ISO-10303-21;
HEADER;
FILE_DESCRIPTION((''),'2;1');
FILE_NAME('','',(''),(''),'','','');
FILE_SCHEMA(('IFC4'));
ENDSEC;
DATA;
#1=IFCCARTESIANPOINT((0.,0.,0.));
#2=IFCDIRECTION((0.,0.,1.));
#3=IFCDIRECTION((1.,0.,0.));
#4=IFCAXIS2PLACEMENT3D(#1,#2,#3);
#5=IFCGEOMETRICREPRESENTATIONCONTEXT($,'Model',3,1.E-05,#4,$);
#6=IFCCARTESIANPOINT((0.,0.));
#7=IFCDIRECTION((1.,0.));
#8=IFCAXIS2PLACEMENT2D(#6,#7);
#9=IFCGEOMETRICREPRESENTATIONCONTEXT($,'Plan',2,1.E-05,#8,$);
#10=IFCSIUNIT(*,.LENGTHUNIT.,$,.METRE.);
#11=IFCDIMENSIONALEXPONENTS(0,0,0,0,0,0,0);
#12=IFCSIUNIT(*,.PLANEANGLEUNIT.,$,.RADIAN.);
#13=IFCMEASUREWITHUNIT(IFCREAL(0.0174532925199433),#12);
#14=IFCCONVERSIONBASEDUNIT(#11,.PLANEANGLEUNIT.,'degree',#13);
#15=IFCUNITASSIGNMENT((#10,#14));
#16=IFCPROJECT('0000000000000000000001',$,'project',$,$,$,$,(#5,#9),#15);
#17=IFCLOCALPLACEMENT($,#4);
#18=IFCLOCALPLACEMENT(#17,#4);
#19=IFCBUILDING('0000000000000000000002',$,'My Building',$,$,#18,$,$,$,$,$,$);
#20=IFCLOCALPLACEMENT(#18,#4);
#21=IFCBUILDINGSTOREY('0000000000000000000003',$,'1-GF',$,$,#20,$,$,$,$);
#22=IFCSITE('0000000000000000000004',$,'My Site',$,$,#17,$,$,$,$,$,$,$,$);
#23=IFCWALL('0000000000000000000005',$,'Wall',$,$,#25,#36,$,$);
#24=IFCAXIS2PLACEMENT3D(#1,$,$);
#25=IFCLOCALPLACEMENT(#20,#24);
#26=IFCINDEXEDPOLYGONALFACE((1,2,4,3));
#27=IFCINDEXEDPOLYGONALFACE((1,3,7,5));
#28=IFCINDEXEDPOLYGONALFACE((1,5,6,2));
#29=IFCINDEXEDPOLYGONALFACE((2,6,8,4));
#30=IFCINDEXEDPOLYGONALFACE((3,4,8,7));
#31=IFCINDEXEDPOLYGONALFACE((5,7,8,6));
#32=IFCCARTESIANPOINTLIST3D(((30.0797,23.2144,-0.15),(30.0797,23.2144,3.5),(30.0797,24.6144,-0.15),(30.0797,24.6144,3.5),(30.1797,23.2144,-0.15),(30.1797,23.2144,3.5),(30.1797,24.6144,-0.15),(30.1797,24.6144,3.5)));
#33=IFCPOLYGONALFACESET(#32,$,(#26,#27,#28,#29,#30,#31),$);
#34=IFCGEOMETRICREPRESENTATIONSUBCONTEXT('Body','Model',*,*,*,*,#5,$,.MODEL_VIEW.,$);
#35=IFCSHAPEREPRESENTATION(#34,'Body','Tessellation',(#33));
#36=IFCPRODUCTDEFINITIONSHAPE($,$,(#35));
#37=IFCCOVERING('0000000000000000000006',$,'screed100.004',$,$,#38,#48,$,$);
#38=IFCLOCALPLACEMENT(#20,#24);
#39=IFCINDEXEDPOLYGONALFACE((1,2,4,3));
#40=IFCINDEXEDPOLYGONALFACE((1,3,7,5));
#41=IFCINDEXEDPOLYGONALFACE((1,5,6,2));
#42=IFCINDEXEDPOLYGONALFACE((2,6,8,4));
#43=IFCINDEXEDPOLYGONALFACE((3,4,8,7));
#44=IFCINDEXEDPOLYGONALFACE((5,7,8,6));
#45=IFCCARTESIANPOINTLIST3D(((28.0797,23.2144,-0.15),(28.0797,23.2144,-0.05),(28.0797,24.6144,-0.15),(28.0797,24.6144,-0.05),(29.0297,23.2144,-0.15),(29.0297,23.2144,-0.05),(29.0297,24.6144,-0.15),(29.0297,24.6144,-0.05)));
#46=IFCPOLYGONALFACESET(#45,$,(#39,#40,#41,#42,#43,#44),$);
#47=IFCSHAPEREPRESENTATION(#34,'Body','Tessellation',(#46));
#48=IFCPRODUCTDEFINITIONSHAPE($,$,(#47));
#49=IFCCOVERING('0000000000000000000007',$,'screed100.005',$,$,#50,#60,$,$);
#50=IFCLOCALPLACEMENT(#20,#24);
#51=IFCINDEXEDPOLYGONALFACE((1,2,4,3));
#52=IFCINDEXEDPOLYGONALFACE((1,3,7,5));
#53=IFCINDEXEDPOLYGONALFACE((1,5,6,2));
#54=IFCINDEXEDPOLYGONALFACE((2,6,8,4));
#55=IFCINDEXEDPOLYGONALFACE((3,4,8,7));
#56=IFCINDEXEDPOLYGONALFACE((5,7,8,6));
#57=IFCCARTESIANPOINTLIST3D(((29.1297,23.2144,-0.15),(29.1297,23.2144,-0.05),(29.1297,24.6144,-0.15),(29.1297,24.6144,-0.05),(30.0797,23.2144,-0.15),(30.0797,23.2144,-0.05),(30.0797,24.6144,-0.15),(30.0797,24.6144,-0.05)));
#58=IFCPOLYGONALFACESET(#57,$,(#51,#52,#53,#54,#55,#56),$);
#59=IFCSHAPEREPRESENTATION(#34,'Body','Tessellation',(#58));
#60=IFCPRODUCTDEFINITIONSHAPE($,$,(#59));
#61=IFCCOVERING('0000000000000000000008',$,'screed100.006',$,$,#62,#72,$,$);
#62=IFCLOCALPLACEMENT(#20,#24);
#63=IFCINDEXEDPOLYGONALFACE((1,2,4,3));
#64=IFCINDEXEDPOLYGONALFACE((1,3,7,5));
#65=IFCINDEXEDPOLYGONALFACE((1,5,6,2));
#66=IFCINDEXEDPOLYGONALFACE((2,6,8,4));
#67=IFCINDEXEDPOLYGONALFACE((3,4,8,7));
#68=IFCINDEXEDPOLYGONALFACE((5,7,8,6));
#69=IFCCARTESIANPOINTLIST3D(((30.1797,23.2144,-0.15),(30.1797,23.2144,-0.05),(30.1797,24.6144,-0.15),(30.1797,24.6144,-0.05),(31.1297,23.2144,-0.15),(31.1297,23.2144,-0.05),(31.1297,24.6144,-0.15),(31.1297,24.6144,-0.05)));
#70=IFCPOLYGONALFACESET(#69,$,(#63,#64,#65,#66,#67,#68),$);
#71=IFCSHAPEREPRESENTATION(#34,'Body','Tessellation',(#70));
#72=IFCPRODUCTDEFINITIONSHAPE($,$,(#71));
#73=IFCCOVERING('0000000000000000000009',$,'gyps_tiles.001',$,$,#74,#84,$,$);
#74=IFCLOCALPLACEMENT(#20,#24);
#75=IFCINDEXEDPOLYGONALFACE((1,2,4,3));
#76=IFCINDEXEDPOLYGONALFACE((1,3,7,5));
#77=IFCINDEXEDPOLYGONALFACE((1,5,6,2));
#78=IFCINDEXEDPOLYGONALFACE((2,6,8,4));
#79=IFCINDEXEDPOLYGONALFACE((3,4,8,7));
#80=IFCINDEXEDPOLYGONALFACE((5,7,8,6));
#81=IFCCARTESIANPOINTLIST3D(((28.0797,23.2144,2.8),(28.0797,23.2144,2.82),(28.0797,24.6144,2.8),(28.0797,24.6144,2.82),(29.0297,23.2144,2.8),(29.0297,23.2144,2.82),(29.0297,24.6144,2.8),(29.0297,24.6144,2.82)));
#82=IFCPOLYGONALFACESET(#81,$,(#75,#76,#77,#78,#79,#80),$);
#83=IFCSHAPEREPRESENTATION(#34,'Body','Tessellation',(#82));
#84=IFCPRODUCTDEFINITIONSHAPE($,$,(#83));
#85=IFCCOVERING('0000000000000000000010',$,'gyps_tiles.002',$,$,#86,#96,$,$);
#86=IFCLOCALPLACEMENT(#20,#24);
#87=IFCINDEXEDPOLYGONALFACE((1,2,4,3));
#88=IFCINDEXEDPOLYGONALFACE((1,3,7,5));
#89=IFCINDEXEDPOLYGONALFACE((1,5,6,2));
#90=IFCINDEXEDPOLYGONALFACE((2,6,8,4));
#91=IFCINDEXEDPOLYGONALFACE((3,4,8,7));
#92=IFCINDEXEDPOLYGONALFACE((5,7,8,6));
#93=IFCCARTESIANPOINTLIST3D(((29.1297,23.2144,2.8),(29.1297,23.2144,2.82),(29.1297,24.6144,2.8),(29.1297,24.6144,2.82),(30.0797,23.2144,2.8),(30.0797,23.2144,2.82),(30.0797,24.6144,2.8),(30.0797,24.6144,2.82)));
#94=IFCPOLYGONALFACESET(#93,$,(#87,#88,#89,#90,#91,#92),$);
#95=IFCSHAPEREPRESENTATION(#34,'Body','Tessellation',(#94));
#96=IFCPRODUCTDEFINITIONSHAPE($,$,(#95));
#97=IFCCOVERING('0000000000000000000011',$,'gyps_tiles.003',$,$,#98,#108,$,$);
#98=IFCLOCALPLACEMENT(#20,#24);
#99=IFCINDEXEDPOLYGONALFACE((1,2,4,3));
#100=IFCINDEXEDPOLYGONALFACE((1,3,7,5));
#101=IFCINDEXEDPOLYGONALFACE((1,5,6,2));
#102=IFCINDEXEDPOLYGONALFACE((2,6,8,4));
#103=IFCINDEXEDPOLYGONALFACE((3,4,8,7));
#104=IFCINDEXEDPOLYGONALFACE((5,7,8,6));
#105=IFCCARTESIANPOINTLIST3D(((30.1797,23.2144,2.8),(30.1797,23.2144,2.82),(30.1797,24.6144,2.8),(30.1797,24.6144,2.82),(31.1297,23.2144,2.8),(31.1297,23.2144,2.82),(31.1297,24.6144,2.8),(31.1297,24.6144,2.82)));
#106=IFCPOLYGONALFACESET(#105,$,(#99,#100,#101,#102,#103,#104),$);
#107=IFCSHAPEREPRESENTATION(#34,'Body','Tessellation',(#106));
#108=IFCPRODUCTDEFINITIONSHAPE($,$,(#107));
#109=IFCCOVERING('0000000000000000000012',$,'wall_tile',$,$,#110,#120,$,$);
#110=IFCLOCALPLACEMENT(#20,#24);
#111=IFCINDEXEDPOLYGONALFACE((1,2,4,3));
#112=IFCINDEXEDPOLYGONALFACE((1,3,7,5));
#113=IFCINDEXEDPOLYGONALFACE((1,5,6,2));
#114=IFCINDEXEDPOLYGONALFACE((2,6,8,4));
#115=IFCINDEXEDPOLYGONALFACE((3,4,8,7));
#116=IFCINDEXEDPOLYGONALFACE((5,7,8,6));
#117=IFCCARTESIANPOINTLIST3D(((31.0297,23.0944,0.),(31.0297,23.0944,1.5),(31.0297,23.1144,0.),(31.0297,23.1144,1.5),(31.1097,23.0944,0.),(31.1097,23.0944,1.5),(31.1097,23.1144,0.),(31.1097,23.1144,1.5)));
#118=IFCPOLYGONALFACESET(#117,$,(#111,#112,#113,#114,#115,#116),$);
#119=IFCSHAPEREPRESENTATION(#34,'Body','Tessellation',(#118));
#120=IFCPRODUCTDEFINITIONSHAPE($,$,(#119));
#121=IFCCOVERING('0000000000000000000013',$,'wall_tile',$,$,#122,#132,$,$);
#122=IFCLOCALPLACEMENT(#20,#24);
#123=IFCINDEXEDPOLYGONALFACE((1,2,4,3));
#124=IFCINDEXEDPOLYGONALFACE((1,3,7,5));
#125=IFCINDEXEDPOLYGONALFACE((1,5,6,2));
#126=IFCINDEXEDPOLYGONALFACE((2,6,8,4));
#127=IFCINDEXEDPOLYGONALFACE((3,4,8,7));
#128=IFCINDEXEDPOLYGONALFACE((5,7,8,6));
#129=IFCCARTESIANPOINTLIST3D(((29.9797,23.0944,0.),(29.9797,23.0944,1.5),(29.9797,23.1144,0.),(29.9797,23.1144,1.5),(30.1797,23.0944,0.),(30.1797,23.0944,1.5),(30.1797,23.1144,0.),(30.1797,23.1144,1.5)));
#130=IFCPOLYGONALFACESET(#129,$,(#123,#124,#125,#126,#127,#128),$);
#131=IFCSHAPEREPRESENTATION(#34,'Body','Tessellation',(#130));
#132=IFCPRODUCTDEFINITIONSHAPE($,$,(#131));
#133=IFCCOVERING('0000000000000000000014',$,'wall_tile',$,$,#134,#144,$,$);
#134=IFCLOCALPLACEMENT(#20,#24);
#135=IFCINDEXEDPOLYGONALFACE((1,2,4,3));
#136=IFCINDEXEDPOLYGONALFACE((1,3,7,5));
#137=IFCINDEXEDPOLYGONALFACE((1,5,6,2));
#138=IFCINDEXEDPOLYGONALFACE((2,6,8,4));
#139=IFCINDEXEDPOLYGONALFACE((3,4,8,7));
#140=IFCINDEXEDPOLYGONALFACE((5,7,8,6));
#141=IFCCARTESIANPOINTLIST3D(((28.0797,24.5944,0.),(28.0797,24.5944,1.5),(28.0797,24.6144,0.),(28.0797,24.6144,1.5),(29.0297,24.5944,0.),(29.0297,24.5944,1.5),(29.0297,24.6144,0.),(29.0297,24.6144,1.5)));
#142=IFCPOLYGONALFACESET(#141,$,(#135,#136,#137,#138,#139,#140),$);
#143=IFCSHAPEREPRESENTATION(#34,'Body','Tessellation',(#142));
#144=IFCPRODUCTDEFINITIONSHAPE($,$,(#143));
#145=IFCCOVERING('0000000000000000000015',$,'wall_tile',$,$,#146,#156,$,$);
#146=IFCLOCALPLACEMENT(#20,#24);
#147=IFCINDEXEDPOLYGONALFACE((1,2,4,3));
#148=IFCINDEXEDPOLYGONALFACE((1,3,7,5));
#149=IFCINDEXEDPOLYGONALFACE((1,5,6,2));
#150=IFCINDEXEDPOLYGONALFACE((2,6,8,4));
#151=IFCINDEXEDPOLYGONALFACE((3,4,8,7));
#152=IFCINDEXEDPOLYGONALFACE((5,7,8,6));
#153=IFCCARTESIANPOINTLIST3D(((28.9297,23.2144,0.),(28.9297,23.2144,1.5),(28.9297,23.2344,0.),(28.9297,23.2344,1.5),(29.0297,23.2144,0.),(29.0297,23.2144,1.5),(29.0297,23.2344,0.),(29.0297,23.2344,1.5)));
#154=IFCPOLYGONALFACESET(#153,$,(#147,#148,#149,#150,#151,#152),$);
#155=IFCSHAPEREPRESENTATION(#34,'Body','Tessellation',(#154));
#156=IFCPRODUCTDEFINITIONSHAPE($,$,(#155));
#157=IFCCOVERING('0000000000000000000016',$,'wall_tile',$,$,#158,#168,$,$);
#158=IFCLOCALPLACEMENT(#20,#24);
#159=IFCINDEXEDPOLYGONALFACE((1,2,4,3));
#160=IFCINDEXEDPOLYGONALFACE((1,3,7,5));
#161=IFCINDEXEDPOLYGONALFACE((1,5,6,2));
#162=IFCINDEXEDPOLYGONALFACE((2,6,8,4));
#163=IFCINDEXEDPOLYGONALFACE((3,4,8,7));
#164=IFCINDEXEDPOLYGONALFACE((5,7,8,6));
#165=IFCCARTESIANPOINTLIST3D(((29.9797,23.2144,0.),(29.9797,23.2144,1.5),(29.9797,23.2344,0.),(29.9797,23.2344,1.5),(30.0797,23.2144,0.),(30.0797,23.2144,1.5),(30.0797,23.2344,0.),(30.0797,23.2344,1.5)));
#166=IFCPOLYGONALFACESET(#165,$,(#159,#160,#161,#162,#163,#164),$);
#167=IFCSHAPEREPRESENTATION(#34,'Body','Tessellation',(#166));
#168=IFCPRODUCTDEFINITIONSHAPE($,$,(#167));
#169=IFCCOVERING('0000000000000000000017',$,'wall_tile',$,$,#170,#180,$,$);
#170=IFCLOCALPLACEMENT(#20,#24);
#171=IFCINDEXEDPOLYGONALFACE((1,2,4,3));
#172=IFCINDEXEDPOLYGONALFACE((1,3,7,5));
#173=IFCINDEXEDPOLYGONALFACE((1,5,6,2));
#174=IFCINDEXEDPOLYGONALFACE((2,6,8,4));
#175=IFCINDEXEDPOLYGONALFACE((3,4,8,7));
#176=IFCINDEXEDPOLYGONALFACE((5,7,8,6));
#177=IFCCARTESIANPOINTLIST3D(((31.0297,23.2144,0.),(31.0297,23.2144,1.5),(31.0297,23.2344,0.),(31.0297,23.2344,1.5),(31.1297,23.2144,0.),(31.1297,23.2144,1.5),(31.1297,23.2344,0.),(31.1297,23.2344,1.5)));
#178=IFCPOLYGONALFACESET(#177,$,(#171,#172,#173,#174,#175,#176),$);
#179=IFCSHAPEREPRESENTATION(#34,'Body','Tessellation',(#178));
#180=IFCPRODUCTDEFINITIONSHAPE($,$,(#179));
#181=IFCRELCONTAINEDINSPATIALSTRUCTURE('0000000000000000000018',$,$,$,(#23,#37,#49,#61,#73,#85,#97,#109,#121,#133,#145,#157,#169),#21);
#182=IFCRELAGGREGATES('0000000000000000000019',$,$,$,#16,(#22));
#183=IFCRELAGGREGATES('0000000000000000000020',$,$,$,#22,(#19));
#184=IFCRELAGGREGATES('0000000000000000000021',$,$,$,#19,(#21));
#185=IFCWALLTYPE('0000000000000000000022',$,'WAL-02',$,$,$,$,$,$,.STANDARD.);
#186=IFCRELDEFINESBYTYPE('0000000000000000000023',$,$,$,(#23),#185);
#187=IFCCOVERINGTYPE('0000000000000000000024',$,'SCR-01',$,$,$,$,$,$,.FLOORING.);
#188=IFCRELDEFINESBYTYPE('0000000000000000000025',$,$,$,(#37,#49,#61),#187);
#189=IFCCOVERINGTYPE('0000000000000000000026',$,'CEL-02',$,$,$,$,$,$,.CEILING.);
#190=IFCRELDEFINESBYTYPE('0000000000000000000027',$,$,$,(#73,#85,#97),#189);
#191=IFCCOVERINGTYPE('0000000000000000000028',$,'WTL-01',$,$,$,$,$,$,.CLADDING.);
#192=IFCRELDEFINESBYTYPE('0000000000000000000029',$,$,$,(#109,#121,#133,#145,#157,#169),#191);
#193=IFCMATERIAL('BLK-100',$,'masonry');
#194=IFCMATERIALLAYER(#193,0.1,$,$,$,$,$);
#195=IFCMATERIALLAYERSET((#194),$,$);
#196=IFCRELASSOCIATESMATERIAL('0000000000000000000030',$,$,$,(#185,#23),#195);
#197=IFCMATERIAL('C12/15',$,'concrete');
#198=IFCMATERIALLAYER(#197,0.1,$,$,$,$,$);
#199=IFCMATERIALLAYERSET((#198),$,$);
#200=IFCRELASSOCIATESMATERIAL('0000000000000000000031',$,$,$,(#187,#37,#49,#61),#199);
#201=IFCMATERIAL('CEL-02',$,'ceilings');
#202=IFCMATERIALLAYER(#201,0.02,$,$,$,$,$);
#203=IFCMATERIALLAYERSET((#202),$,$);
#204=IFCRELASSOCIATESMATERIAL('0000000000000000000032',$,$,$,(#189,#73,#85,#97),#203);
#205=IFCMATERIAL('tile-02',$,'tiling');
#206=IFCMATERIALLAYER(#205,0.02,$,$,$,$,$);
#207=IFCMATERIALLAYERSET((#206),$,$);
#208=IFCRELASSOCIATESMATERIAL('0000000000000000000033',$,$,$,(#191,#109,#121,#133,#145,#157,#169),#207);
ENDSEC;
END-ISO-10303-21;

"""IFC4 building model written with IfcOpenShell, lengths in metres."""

from ifc_helpers import new_model, entity, si_unit, converted_unit, frame, origin_with_axes, origin_2d_with_axis, place, context, subcontext, project, spatial, line, indexed_curve, outline, extrude, material, layer, layer_set, layer_usage, type_object, element, save


model = new_model("IFC4")

# Units and contexts
model_context = context("Model", 3, precision=1e-05, world=origin_with_axes())
plan_context = context("Plan", 2, precision=1e-05, world=origin_2d_with_axis())
body_context_1 = subcontext(model_context, "Body", "Model", "MODEL_VIEW")
ifc_project = project(units=[si_unit("LENGTHUNIT", "METRE"), converted_unit("PLANEANGLEUNIT", "degree", entity("IfcReal", 0.0174532925199433), si_unit("PLANEANGLEUNIT", "RADIAN"), dimensions=[0, 0, 0, 0, 0, 0, 0])], contexts=[model_context, plan_context])

# Site, building, storey
site_placement = place(None, origin_with_axes())
site = spatial("IfcSite", under=ifc_project, at=site_placement, Name="My Site")
building_placement = place(site_placement, origin_with_axes())
building = spatial("IfcBuilding", under=site, at=building_placement, Name="My Building")
storey_placement = place(building_placement, origin_with_axes())
storey = spatial("IfcBuildingStorey", under=building, at=storey_placement, Name="1-GF")

# Wall
ifc_material_1 = material(Name="BLK-100", Category="masonry")
ifc_layer_1 = layer(ifc_material_1, 0.1)
ifc_layer_set_1 = layer_set([ifc_layer_1])
wall_type_1 = type_object("IfcWallType", Name="WAL-02", PredefinedType="STANDARD", material=ifc_layer_set_1)
ifc_layer_usage_1 = layer_usage(ifc_layer_set_1, "AXIS2", "POSITIVE", 0.0)
wall_1_placement = place(storey_placement, frame((30.1797, 23.2144, -0.15), z_axis=(0.0, 0.0, 1.0), x_axis=(0.0, 1.0, 0.0)))
element("IfcWall", 1, at=wall_1_placement, inside=storey, type_object=wall_type_1, material=ifc_layer_usage_1, Name="Wall", context=body_context_1, shape_type="SweptSolid", body=[
    extrude(outline(indexed_curve([(0.0, 0.0), (0.0, 0.1), (1.4, 0.1), (1.4, 0.0), (0.0, 0.0)], self_intersect=False)), origin_with_axes(), (0.0, 0.0, 1.0), 3.65),
])

# Coverings
ifc_material_2 = material(Name="C12/15", Category="concrete")
ifc_layer_2 = layer(ifc_material_2, 0.1)
ifc_layer_set_2 = layer_set([ifc_layer_2])
ifc_layer_usage_2 = layer_usage(ifc_layer_set_2, "AXIS3", "POSITIVE", 0.0)
covering_type_1 = type_object("IfcCoveringType", Name="SCR-01", PredefinedType="FLOORING", material=ifc_layer_set_2)
covering_1_placement = place(storey_placement, frame((28.0797, 23.2144, -0.15), z_axis=(0.0, 0.0, 1.0), x_axis=(1.0, 0.0, 0.0)))
element("IfcCovering", 2, at=covering_1_placement, inside=storey, type_object=covering_type_1, material=ifc_layer_usage_2, Name="screed100.004", context=body_context_1, shape_type="SweptSolid", body=[
    extrude(outline(indexed_curve([(0.0, 0.0), (0.95, 0.0), (0.95, 1.4), (0.0, 1.4)], segments=[line(4, 1), line(1, 2), line(2, 3), line(3, 4)], self_intersect=False)), None, (0.0, 0.0, 1.0), 0.1),
])
ifc_layer_usage_3 = layer_usage(ifc_layer_set_2, "AXIS3", "POSITIVE", 0.0)
covering_2_placement = place(storey_placement, frame((29.1297, 23.2144, -0.15), z_axis=(0.0, 0.0, 1.0), x_axis=(1.0, 0.0, 0.0)))
element("IfcCovering", 3, at=covering_2_placement, inside=storey, type_object=covering_type_1, material=ifc_layer_usage_3, Name="screed100.005", context=body_context_1, shape_type="SweptSolid", body=[
    extrude(outline(indexed_curve([(0.0, 0.0), (0.95, 0.0), (0.95, 1.4), (0.0, 1.4)], segments=[line(4, 1), line(1, 2), line(2, 3), line(3, 4)], self_intersect=False)), None, (0.0, 0.0, 1.0), 0.1),
])
ifc_layer_usage_4 = layer_usage(ifc_layer_set_2, "AXIS3", "POSITIVE", 0.0)
covering_3_placement = place(storey_placement, frame((30.1797, 23.2144, -0.15), z_axis=(0.0, 0.0, 1.0), x_axis=(1.0, 0.0, 0.0)))
element("IfcCovering", 4, at=covering_3_placement, inside=storey, type_object=covering_type_1, material=ifc_layer_usage_4, Name="screed100.006", context=body_context_1, shape_type="SweptSolid", body=[
    extrude(outline(indexed_curve([(0.0, 0.0), (0.95, 0.0), (0.95, 1.4), (0.0, 1.4)], segments=[line(4, 1), line(1, 2), line(2, 3), line(3, 4)], self_intersect=False)), None, (0.0, 0.0, 1.0), 0.1),
])
ifc_material_3 = material(Name="CEL-02", Category="ceilings")
ifc_layer_3 = layer(ifc_material_3, 0.02)
ifc_layer_set_3 = layer_set([ifc_layer_3])
ifc_layer_usage_5 = layer_usage(ifc_layer_set_3, "AXIS3", "POSITIVE", 0.0)
covering_type_2 = type_object("IfcCoveringType", Name="CEL-02", PredefinedType="CEILING", material=ifc_layer_set_3)
covering_4_placement = place(storey_placement, frame((28.0797, 23.2144, 2.8), z_axis=(0.0, 0.0, 1.0), x_axis=(1.0, 0.0, 0.0)))
element("IfcCovering", 5, at=covering_4_placement, inside=storey, type_object=covering_type_2, material=ifc_layer_usage_5, Name="gyps_tiles.001", context=body_context_1, shape_type="SweptSolid", body=[
    extrude(outline(indexed_curve([(0.0, 0.0), (0.95, 0.0), (0.95, 1.4), (0.0, 1.4)], segments=[line(4, 1), line(1, 2), line(2, 3), line(3, 4)], self_intersect=False)), None, (0.0, 0.0, 1.0), 0.02),
])
ifc_layer_usage_6 = layer_usage(ifc_layer_set_3, "AXIS3", "POSITIVE", 0.0)
covering_5_placement = place(storey_placement, frame((29.1297, 23.2144, 2.8), z_axis=(0.0, 0.0, 1.0), x_axis=(1.0, 0.0, 0.0)))
element("IfcCovering", 6, at=covering_5_placement, inside=storey, type_object=covering_type_2, material=ifc_layer_usage_6, Name="gyps_tiles.002", context=body_context_1, shape_type="SweptSolid", body=[
    extrude(outline(indexed_curve([(0.0, 0.0), (0.95, 0.0), (0.95, 1.4), (0.0, 1.4)], segments=[line(4, 1), line(1, 2), line(2, 3), line(3, 4)], self_intersect=False)), None, (0.0, 0.0, 1.0), 0.02),
])
ifc_layer_usage_7 = layer_usage(ifc_layer_set_3, "AXIS3", "POSITIVE", 0.0)
covering_6_placement = place(storey_placement, frame((30.1797, 23.2144, 2.8), z_axis=(0.0, 0.0, 1.0), x_axis=(1.0, 0.0, 0.0)))
element("IfcCovering", 7, at=covering_6_placement, inside=storey, type_object=covering_type_2, material=ifc_layer_usage_7, Name="gyps_tiles.003", context=body_context_1, shape_type="SweptSolid", body=[
    extrude(outline(indexed_curve([(0.0, 0.0), (0.95, 0.0), (0.95, 1.4), (0.0, 1.4)], segments=[line(4, 1), line(1, 2), line(2, 3), line(3, 4)], self_intersect=False)), None, (0.0, 0.0, 1.0), 0.02),
])
ifc_material_4 = material(Name="tile-02", Category="tiling")
ifc_layer_4 = layer(ifc_material_4, 0.02)
ifc_layer_set_4 = layer_set([ifc_layer_4])
ifc_layer_usage_8 = layer_usage(ifc_layer_set_4, "AXIS2", "POSITIVE", 0.0)
covering_type_3 = type_object("IfcCoveringType", Name="WTL-01", PredefinedType="CLADDING", material=ifc_layer_set_4)
covering_7_placement = place(storey_placement, frame((31.1097, 23.1144, 0.0), z_axis=(0.0, 0.0, 1.0), x_axis=(-1.0, 0.000001, 0.0)))
element("IfcCovering", 8, at=covering_7_placement, inside=storey, type_object=covering_type_3, material=ifc_layer_usage_8, Name="wall_tile", context=body_context_1, shape_type="SweptSolid", body=[
    extrude(outline(indexed_curve([(0.0, 0.0), (0.0, 0.02), (0.08, 0.02), (0.08, 0.0), (0.0, 0.0)], self_intersect=False)), origin_with_axes(), (0.0, 0.0, 1.0), 1.5),
])
ifc_layer_usage_9 = layer_usage(ifc_layer_set_4, "AXIS2", "POSITIVE", 0.0)
covering_8_placement = place(storey_placement, frame((30.1797, 23.1144, 0.0), z_axis=(0.0, 0.0, 1.0), x_axis=(-1.0, 0.000001, 0.0)))
element("IfcCovering", 9, at=covering_8_placement, inside=storey, type_object=covering_type_3, material=ifc_layer_usage_9, Name="wall_tile", context=body_context_1, shape_type="SweptSolid", body=[
    extrude(outline(indexed_curve([(0.0, 0.0), (0.0, 0.02), (0.2, 0.02), (0.2, 0.0), (0.0, 0.0)], self_intersect=False)), origin_with_axes(), (0.0, 0.0, 1.0), 1.5),
])
ifc_layer_usage_10 = layer_usage(ifc_layer_set_4, "AXIS2", "POSITIVE", 0.0)
covering_9_placement = place(storey_placement, frame((29.0297, 24.6144, 0.0), z_axis=(0.0, 0.0, 1.0), x_axis=(-1.0, 0.000001, 0.0)))
element("IfcCovering", 10, at=covering_9_placement, inside=storey, type_object=covering_type_3, material=ifc_layer_usage_10, Name="wall_tile", context=body_context_1, shape_type="SweptSolid", body=[
    extrude(outline(indexed_curve([(0.0, 0.0), (0.0, 0.02), (0.95, 0.02), (0.95, 0.0), (0.0, 0.0)], self_intersect=False)), origin_with_axes(), (0.0, 0.0, 1.0), 1.5),
])
ifc_layer_usage_11 = layer_usage(ifc_layer_set_4, "AXIS2", "POSITIVE", 0.0)
covering_10_placement = place(storey_placement, frame((29.0297, 23.2344, 0.0), z_axis=(0.0, 0.0, 1.0), x_axis=(-1.0, 0.000001, 0.0)))
element("IfcCovering", 11, at=covering_10_placement, inside=storey, type_object=covering_type_3, material=ifc_layer_usage_11, Name="wall_tile", context=body_context_1, shape_type="SweptSolid", body=[
    extrude(outline(indexed_curve([(0.0, 0.0), (0.0, 0.02), (0.1, 0.02), (0.1, 0.0), (0.0, 0.0)], self_intersect=False)), origin_with_axes(), (0.0, 0.0, 1.0), 1.5),
])
ifc_layer_usage_12 = layer_usage(ifc_layer_set_4, "AXIS2", "POSITIVE", 0.0)
covering_11_placement = place(storey_placement, frame((30.0797, 23.2344, 0.0), z_axis=(0.0, 0.0, 1.0), x_axis=(-1.0, 0.000001, 0.0)))
element("IfcCovering", 12, at=covering_11_placement, inside=storey, type_object=covering_type_3, material=ifc_layer_usage_12, Name="wall_tile", context=body_context_1, shape_type="SweptSolid", body=[
    extrude(outline(indexed_curve([(0.0, 0.0), (0.0, 0.02), (0.1, 0.02), (0.1, 0.0), (0.0, 0.0)], self_intersect=False)), origin_with_axes(), (0.0, 0.0, 1.0), 1.5),
])
ifc_layer_usage_13 = layer_usage(ifc_layer_set_4, "AXIS2", "POSITIVE", 0.0)
covering_12_placement = place(storey_placement, frame((31.1297, 23.2344, 0.0), z_axis=(0.0, 0.0, 1.0), x_axis=(-1.0, 0.000001, 0.0)))
element("IfcCovering", 13, at=covering_12_placement, inside=storey, type_object=covering_type_3, material=ifc_layer_usage_13, Name="wall_tile", context=body_context_1, shape_type="SweptSolid", body=[
    extrude(outline(indexed_curve([(0.0, 0.0), (0.0, 0.02), (0.1, 0.02), (0.1, 0.0), (0.0, 0.0)], self_intersect=False)), origin_with_axes(), (0.0, 0.0, 1.0), 1.5),
])

save(model, "model.ifc")
